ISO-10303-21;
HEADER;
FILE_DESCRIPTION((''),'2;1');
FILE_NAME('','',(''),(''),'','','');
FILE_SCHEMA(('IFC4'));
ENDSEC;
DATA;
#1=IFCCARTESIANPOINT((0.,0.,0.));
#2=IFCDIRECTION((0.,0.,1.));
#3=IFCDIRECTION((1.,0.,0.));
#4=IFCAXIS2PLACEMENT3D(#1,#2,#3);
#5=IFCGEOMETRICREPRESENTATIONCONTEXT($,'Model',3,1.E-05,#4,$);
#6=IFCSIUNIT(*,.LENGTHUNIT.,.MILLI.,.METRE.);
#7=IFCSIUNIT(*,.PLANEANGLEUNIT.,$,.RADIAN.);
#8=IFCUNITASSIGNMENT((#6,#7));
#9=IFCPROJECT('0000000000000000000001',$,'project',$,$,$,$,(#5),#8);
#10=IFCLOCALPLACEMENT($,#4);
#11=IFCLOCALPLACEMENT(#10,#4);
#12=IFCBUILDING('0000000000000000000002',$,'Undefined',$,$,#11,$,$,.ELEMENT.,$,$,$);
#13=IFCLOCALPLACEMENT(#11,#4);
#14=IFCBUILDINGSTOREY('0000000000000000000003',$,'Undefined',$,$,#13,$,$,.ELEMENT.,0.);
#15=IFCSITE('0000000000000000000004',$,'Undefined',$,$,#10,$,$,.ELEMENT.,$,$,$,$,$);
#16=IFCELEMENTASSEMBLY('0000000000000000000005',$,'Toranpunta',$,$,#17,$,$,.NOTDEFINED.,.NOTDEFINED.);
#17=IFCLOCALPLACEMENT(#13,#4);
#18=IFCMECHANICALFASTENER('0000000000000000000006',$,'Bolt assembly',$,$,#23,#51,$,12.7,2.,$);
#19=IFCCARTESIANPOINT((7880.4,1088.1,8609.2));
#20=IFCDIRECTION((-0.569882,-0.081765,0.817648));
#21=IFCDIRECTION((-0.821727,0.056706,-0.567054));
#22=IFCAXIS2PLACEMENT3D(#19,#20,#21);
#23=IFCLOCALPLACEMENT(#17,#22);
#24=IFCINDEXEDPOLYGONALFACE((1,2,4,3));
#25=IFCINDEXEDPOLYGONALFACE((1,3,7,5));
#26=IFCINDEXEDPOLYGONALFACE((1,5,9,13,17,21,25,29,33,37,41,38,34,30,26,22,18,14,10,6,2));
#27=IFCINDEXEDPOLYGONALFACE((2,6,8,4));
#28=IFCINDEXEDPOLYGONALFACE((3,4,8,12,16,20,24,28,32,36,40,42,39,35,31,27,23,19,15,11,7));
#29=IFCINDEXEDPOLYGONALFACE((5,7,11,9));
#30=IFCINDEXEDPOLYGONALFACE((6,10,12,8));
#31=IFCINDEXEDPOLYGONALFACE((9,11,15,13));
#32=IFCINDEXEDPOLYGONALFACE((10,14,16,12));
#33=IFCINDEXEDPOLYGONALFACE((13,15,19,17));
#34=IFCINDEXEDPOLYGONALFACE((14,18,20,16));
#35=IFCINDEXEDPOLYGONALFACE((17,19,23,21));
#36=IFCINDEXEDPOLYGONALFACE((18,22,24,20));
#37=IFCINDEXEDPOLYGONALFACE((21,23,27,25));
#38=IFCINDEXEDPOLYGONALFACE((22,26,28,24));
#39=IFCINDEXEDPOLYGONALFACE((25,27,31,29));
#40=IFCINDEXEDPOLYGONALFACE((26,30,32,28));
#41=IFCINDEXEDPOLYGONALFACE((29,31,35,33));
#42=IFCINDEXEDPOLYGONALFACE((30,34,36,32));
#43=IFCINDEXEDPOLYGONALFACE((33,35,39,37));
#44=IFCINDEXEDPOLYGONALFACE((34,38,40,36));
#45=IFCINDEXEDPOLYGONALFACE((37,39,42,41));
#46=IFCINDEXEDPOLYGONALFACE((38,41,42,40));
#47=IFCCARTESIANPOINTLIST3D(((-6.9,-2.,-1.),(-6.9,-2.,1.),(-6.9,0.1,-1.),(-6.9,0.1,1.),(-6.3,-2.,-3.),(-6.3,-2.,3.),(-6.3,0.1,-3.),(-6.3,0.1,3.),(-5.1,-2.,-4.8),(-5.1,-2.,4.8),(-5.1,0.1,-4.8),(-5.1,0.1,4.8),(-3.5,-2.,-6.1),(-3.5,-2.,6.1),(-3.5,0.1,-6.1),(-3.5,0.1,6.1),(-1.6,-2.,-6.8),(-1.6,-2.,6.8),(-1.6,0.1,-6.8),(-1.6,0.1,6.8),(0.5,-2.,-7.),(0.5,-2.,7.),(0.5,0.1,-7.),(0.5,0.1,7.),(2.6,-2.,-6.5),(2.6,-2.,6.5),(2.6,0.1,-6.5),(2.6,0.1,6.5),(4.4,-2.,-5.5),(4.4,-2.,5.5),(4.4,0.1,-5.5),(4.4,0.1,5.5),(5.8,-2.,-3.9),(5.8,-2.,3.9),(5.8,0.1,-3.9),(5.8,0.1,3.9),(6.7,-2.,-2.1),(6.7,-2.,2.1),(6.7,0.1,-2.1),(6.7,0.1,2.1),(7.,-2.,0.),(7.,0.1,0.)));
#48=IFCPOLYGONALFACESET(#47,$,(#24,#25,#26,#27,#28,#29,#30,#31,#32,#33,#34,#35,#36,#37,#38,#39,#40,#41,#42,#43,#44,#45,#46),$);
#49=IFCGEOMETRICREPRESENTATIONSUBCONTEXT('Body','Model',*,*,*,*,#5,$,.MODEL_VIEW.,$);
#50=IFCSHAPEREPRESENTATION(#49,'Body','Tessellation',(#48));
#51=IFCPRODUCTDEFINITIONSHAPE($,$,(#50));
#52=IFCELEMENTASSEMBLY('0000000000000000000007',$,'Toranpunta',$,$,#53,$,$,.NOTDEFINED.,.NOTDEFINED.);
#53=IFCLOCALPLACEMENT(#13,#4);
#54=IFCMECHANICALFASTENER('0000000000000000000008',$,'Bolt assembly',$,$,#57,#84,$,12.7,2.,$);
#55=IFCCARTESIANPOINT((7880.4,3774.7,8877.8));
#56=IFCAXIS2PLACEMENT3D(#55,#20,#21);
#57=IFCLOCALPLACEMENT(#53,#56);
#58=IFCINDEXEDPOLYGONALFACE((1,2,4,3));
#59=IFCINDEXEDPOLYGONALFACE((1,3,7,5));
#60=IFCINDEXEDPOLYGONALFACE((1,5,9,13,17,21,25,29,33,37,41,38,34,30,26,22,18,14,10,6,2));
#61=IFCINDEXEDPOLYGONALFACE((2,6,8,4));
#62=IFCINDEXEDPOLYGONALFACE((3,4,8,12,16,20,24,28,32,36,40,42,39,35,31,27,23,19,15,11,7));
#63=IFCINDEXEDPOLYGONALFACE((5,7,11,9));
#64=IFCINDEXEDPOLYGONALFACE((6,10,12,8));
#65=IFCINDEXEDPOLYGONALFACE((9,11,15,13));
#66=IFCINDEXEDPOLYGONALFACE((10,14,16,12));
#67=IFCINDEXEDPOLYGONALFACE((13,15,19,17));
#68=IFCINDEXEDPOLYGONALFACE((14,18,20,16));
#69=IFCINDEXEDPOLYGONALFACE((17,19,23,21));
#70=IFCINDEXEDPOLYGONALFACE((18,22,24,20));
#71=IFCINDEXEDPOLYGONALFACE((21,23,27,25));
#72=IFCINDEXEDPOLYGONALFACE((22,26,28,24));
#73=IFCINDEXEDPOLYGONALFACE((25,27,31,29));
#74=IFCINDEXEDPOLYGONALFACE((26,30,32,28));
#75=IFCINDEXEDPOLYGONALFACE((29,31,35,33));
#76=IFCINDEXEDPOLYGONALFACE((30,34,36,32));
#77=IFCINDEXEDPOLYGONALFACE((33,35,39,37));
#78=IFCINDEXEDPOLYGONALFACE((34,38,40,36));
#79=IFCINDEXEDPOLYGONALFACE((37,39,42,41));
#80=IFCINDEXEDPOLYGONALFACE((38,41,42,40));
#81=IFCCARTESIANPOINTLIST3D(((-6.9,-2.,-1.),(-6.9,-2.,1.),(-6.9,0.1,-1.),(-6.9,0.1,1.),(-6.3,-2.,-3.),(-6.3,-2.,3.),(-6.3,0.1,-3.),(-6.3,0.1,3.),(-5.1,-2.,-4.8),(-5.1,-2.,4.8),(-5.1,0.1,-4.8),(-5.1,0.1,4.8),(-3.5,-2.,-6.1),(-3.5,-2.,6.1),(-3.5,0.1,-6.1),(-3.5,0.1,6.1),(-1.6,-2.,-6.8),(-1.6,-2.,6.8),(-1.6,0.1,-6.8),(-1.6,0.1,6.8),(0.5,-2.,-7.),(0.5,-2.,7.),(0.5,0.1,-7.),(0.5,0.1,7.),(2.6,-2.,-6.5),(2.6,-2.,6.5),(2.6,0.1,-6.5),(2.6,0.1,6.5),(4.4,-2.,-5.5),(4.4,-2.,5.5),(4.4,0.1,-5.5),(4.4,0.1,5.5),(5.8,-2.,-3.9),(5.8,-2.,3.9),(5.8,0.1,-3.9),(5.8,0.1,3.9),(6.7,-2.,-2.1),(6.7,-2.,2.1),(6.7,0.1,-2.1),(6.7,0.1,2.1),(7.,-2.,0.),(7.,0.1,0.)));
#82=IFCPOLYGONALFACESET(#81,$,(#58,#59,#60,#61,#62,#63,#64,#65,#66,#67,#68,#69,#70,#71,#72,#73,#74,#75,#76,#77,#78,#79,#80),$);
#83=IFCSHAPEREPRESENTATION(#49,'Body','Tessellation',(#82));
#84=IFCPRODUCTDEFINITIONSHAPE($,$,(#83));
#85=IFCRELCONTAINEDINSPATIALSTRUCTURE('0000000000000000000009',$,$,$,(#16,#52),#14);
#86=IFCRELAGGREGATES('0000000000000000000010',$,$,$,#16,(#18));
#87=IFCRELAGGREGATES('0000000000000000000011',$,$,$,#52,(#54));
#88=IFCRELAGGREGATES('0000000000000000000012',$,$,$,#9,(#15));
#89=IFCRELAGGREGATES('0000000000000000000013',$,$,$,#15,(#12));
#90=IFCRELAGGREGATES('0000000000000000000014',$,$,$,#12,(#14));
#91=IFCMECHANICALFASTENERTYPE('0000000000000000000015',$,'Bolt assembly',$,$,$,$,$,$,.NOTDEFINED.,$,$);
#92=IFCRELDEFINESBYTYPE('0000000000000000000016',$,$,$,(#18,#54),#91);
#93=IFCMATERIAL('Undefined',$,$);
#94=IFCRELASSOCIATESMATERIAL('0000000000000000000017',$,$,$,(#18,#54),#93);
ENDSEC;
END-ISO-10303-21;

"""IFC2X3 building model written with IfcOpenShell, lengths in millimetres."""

from ifc_helpers import new_model, si_unit, frame, origin_with_axes, origin_2d_with_axis, place, context, subcontext, project, spatial, circle, extrude, source, transform, mapped, material, type_object, element, aggregate, save


model = new_model("IFC2X3")

# Units and contexts
model_context = context("Model", 3, precision=1e-05, world=origin_with_axes())
body_context = subcontext(model_context, "Body", "Model", "MODEL_VIEW")
ifc_project = project(units=[si_unit("LENGTHUNIT", "METRE", prefix="MILLI"), si_unit("PLANEANGLEUNIT", "RADIAN")], contexts=[model_context])

# Site, building, storey
site_placement = place(None, origin_with_axes())
site = spatial("IfcSite", under=ifc_project, at=site_placement, Name="Undefined", CompositionType="ELEMENT")
building_placement = place(site_placement, origin_with_axes())
building = spatial("IfcBuilding", under=site, at=building_placement, Name="Undefined", CompositionType="ELEMENT")
storey_placement = place(building_placement, origin_with_axes())
storey = spatial("IfcBuildingStorey", under=building, at=storey_placement, Name="Undefined", CompositionType="ELEMENT", Elevation=0.0)

# Shared definitions
ifc_material_1 = material(Name="Undefined")
mechanical_fastener_type = type_object("IfcMechanicalFastenerType", Name="Bolt assembly")

# Element assemblies, mechanical fasteners
assembly_1_placement = place(storey_placement, origin_with_axes())
assembly_1 = element("IfcElementAssembly", 1, at=assembly_1_placement, inside=storey, Name="Toranpunta", AssemblyPlace="NOTDEFINED", PredefinedType="NOTDEFINED")
shared_shape_1 = source(origin_with_axes(), body_context, "Body", "SweptSolid", [
    extrude(circle(Radius=7.0, at=origin_2d_with_axis()), frame((0.0, -2.0, 0.0), z_axis=(0.0, 1.0, 0.0), x_axis=(1.0, 0.0, 0.0)), (0.0, 0.0, 1.0), 2.1),
])
mechanical_fastener_1_placement = place(assembly_1_placement, frame((7880.4, 1088.1, 8609.2), z_axis=(-0.569882, -0.081765, 0.817648), x_axis=(-0.821727, 0.056706, -0.567054)))
mechanical_fastener_1 = element("IfcMechanicalFastener", 2, at=mechanical_fastener_1_placement, type_object=mechanical_fastener_type, material=ifc_material_1, Name="Bolt assembly", NominalDiameter=12.7, NominalLength=2.0, context=body_context, shape_type="MappedRepresentation", body=[
    mapped(shared_shape_1, transform((0.0, 0.0, 0.0))),
])
aggregate(assembly_1, [mechanical_fastener_1])
assembly_2_placement = place(storey_placement, origin_with_axes())
assembly_2 = element("IfcElementAssembly", 3, at=assembly_2_placement, inside=storey, Name="Toranpunta", AssemblyPlace="NOTDEFINED", PredefinedType="NOTDEFINED")
mechanical_fastener_2_placement = place(assembly_2_placement, frame((7880.4, 3774.7, 8877.8), z_axis=(-0.569882, -0.081765, 0.817648), x_axis=(-0.821727, 0.056706, -0.567054)))
mechanical_fastener_2 = element("IfcMechanicalFastener", 4, at=mechanical_fastener_2_placement, type_object=mechanical_fastener_type, material=ifc_material_1, Name="Bolt assembly", NominalDiameter=12.7, NominalLength=2.0, context=body_context, shape_type="MappedRepresentation", body=[
    mapped(shared_shape_1, transform((0.0, 0.0, 0.0))),
])
aggregate(assembly_2, [mechanical_fastener_2])

save(model, "model.ifc")
